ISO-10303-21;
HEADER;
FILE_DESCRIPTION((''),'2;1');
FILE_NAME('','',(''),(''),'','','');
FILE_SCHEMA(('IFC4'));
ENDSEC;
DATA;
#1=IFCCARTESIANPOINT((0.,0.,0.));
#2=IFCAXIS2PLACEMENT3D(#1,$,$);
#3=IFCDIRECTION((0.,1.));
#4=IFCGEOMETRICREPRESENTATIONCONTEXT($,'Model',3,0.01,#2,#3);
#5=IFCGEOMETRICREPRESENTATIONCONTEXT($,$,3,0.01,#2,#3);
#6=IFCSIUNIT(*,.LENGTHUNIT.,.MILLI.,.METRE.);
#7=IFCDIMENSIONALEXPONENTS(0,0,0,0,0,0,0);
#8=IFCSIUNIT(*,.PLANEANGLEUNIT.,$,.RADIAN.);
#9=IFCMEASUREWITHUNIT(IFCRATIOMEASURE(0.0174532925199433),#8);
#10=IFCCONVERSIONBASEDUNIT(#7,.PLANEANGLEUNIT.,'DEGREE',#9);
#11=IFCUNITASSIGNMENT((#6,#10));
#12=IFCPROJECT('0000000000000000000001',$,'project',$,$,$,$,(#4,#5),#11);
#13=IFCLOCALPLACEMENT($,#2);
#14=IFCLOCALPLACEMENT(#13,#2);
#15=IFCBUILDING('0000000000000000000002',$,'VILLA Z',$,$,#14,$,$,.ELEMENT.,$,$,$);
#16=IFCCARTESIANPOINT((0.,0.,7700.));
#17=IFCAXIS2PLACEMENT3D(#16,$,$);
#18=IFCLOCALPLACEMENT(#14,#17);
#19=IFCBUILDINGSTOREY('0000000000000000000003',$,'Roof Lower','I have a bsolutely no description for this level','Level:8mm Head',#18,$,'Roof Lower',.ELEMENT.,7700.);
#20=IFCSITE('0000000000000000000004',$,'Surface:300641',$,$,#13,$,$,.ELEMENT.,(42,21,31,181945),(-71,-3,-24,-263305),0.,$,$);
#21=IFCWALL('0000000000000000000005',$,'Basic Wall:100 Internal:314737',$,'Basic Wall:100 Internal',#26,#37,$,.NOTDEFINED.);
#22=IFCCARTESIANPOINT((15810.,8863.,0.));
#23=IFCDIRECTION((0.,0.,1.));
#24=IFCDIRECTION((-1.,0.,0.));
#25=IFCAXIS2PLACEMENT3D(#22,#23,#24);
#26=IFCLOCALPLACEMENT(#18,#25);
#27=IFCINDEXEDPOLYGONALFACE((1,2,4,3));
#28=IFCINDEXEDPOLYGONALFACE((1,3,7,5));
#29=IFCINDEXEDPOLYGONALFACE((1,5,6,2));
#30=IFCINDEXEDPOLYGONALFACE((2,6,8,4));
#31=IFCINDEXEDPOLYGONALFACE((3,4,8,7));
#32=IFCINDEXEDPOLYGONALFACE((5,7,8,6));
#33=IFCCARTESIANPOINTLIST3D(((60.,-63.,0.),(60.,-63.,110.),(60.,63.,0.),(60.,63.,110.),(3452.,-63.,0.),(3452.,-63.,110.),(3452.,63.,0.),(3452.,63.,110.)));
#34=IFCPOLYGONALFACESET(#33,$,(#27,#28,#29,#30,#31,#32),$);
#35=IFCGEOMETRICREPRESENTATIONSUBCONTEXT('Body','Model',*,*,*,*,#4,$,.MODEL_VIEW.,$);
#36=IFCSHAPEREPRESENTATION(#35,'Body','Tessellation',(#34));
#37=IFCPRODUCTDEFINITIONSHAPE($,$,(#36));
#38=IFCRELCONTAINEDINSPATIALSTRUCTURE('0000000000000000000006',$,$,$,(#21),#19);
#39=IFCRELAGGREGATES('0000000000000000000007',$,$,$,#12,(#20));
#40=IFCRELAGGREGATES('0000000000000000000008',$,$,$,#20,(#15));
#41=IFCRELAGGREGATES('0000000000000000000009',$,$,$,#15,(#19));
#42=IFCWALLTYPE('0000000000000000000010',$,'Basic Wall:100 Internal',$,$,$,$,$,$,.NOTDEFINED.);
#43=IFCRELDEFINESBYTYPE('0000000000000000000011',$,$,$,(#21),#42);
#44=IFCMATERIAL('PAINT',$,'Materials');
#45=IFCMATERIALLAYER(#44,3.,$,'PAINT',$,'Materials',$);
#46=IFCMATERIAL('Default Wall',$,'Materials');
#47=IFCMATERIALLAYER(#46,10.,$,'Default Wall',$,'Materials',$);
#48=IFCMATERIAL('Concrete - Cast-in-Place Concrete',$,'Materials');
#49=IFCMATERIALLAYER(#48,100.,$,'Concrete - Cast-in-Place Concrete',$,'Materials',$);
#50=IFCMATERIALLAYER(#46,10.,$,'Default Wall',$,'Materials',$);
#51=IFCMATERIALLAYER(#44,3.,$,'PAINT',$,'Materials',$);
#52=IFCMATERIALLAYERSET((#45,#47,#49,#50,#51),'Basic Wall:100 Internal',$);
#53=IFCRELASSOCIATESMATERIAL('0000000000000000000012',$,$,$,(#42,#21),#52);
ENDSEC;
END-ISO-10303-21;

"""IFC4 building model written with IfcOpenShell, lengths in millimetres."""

from ifc_helpers import new_model, entity, si_unit, converted_unit, direction, frame, frame_2d, origin, place, context, subcontext, project, spatial, polyline, rectangle, extrude, clip, halfspace, bounded_halfspace, material, layer, layer_set, layer_usage, type_object, element, save


model = new_model("IFC4")

# Units and contexts
model_context = context("Model", 3, precision=0.01, world=origin(), true_north=direction((0.0, 1.0)))
context_of_model = context(None, 3, precision=0.01, world=origin(), true_north=direction((0.0, 1.0)))
body_context = subcontext(model_context, "Body", "Model", "MODEL_VIEW")
ifc_project = project(units=[si_unit("LENGTHUNIT", "METRE", prefix="MILLI"), converted_unit("PLANEANGLEUNIT", "DEGREE", entity("IfcRatioMeasure", 0.0174532925199433), si_unit("PLANEANGLEUNIT", "RADIAN"), dimensions=[0, 0, 0, 0, 0, 0, 0])], contexts=[model_context, context_of_model])

# Site, building, storey
site_placement = place(None, origin())
site = spatial("IfcSite", under=ifc_project, at=site_placement, Name="Surface:300641", CompositionType="ELEMENT", RefLatitude=(42, 21, 31, 181945), RefLongitude=(-71, -3, -24, -263305), RefElevation=0.0)
building_placement = place(site_placement, origin())
building = spatial("IfcBuilding", under=site, at=building_placement, Name="VILLA Z", CompositionType="ELEMENT")
storey_placement = place(building_placement, frame((0.0, 0.0, 7700.0)))
storey = spatial("IfcBuildingStorey", under=building, at=storey_placement, Name="Roof Lower", Description="I have a bsolutely no description for this level", ObjectType="Level:8mm Head", LongName="Roof Lower", CompositionType="ELEMENT", Elevation=7700.0)

# Shared definitions
ifc_material_1 = material(Name="Concrete - Cast-in-Place Concrete", Category="Materials")

# Wall
ifc_material_2 = material(Name="PAINT", Category="Materials")
ifc_material_3 = material(Name="Default Wall", Category="Materials")
ifc_layer_1 = layer(ifc_material_2, 3.0, Name="PAINT", Category="Materials")
ifc_layer_2 = layer(ifc_material_3, 10.0, Name="Default Wall", Category="Materials")
ifc_layer_3 = layer(ifc_material_1, 100.0, Name="Concrete - Cast-in-Place Concrete", Category="Materials")
ifc_layer_4 = layer(ifc_material_3, 10.0, Name="Default Wall", Category="Materials")
ifc_layer_5 = layer(ifc_material_2, 3.0, Name="PAINT", Category="Materials")
ifc_layer_set_1 = layer_set([ifc_layer_1, ifc_layer_2, ifc_layer_3, ifc_layer_4, ifc_layer_5], Name="Basic Wall:100 Internal")
wall_type_1 = type_object("IfcWallType", Name="Basic Wall:100 Internal", PredefinedType="NOTDEFINED", material=ifc_layer_set_1)
ifc_layer_usage_1 = layer_usage(ifc_layer_set_1, "AXIS2", "NEGATIVE", 63.0)
wall_1_placement = place(storey_placement, frame((15810.0, 8863.0, 0.0), z_axis=(0.0, 0.0, 1.0), x_axis=(-1.0, 0.0, 0.0)))
element("IfcWall", 1, at=wall_1_placement, inside=storey, type_object=wall_type_1, material=ifc_layer_usage_1, Name="Basic Wall:100 Internal:314737", ObjectType="Basic Wall:100 Internal", PredefinedType="NOTDEFINED", context=body_context, shape_type="Clipping", body=[
    clip(clip(extrude(rectangle(XDim=3392.0, YDim=126.0, at=frame_2d((1756.0, 0.0), x_axis=(-1.0, 0.0))), origin(), (0.0, 0.0, 1.0), 110.0), bounded_halfspace(frame((0.0, -63.0, 110.0), z_axis=(0.0, 0.0, -1.0), x_axis=(-1.0, 0.0, 0.0)), True, frame((0.0, -63.0, 110.0)), polyline([(0.0, 0.0), (3361.6, 0.0), (3452.0, 0.0), (3452.0, 126.0), (60.0, 126.0), (0.0, 126.0), (0.0, 0.0)]))), halfspace(frame((0.0, 0.0, -3500.0)), True)),
])

save(model, "model.ifc")
